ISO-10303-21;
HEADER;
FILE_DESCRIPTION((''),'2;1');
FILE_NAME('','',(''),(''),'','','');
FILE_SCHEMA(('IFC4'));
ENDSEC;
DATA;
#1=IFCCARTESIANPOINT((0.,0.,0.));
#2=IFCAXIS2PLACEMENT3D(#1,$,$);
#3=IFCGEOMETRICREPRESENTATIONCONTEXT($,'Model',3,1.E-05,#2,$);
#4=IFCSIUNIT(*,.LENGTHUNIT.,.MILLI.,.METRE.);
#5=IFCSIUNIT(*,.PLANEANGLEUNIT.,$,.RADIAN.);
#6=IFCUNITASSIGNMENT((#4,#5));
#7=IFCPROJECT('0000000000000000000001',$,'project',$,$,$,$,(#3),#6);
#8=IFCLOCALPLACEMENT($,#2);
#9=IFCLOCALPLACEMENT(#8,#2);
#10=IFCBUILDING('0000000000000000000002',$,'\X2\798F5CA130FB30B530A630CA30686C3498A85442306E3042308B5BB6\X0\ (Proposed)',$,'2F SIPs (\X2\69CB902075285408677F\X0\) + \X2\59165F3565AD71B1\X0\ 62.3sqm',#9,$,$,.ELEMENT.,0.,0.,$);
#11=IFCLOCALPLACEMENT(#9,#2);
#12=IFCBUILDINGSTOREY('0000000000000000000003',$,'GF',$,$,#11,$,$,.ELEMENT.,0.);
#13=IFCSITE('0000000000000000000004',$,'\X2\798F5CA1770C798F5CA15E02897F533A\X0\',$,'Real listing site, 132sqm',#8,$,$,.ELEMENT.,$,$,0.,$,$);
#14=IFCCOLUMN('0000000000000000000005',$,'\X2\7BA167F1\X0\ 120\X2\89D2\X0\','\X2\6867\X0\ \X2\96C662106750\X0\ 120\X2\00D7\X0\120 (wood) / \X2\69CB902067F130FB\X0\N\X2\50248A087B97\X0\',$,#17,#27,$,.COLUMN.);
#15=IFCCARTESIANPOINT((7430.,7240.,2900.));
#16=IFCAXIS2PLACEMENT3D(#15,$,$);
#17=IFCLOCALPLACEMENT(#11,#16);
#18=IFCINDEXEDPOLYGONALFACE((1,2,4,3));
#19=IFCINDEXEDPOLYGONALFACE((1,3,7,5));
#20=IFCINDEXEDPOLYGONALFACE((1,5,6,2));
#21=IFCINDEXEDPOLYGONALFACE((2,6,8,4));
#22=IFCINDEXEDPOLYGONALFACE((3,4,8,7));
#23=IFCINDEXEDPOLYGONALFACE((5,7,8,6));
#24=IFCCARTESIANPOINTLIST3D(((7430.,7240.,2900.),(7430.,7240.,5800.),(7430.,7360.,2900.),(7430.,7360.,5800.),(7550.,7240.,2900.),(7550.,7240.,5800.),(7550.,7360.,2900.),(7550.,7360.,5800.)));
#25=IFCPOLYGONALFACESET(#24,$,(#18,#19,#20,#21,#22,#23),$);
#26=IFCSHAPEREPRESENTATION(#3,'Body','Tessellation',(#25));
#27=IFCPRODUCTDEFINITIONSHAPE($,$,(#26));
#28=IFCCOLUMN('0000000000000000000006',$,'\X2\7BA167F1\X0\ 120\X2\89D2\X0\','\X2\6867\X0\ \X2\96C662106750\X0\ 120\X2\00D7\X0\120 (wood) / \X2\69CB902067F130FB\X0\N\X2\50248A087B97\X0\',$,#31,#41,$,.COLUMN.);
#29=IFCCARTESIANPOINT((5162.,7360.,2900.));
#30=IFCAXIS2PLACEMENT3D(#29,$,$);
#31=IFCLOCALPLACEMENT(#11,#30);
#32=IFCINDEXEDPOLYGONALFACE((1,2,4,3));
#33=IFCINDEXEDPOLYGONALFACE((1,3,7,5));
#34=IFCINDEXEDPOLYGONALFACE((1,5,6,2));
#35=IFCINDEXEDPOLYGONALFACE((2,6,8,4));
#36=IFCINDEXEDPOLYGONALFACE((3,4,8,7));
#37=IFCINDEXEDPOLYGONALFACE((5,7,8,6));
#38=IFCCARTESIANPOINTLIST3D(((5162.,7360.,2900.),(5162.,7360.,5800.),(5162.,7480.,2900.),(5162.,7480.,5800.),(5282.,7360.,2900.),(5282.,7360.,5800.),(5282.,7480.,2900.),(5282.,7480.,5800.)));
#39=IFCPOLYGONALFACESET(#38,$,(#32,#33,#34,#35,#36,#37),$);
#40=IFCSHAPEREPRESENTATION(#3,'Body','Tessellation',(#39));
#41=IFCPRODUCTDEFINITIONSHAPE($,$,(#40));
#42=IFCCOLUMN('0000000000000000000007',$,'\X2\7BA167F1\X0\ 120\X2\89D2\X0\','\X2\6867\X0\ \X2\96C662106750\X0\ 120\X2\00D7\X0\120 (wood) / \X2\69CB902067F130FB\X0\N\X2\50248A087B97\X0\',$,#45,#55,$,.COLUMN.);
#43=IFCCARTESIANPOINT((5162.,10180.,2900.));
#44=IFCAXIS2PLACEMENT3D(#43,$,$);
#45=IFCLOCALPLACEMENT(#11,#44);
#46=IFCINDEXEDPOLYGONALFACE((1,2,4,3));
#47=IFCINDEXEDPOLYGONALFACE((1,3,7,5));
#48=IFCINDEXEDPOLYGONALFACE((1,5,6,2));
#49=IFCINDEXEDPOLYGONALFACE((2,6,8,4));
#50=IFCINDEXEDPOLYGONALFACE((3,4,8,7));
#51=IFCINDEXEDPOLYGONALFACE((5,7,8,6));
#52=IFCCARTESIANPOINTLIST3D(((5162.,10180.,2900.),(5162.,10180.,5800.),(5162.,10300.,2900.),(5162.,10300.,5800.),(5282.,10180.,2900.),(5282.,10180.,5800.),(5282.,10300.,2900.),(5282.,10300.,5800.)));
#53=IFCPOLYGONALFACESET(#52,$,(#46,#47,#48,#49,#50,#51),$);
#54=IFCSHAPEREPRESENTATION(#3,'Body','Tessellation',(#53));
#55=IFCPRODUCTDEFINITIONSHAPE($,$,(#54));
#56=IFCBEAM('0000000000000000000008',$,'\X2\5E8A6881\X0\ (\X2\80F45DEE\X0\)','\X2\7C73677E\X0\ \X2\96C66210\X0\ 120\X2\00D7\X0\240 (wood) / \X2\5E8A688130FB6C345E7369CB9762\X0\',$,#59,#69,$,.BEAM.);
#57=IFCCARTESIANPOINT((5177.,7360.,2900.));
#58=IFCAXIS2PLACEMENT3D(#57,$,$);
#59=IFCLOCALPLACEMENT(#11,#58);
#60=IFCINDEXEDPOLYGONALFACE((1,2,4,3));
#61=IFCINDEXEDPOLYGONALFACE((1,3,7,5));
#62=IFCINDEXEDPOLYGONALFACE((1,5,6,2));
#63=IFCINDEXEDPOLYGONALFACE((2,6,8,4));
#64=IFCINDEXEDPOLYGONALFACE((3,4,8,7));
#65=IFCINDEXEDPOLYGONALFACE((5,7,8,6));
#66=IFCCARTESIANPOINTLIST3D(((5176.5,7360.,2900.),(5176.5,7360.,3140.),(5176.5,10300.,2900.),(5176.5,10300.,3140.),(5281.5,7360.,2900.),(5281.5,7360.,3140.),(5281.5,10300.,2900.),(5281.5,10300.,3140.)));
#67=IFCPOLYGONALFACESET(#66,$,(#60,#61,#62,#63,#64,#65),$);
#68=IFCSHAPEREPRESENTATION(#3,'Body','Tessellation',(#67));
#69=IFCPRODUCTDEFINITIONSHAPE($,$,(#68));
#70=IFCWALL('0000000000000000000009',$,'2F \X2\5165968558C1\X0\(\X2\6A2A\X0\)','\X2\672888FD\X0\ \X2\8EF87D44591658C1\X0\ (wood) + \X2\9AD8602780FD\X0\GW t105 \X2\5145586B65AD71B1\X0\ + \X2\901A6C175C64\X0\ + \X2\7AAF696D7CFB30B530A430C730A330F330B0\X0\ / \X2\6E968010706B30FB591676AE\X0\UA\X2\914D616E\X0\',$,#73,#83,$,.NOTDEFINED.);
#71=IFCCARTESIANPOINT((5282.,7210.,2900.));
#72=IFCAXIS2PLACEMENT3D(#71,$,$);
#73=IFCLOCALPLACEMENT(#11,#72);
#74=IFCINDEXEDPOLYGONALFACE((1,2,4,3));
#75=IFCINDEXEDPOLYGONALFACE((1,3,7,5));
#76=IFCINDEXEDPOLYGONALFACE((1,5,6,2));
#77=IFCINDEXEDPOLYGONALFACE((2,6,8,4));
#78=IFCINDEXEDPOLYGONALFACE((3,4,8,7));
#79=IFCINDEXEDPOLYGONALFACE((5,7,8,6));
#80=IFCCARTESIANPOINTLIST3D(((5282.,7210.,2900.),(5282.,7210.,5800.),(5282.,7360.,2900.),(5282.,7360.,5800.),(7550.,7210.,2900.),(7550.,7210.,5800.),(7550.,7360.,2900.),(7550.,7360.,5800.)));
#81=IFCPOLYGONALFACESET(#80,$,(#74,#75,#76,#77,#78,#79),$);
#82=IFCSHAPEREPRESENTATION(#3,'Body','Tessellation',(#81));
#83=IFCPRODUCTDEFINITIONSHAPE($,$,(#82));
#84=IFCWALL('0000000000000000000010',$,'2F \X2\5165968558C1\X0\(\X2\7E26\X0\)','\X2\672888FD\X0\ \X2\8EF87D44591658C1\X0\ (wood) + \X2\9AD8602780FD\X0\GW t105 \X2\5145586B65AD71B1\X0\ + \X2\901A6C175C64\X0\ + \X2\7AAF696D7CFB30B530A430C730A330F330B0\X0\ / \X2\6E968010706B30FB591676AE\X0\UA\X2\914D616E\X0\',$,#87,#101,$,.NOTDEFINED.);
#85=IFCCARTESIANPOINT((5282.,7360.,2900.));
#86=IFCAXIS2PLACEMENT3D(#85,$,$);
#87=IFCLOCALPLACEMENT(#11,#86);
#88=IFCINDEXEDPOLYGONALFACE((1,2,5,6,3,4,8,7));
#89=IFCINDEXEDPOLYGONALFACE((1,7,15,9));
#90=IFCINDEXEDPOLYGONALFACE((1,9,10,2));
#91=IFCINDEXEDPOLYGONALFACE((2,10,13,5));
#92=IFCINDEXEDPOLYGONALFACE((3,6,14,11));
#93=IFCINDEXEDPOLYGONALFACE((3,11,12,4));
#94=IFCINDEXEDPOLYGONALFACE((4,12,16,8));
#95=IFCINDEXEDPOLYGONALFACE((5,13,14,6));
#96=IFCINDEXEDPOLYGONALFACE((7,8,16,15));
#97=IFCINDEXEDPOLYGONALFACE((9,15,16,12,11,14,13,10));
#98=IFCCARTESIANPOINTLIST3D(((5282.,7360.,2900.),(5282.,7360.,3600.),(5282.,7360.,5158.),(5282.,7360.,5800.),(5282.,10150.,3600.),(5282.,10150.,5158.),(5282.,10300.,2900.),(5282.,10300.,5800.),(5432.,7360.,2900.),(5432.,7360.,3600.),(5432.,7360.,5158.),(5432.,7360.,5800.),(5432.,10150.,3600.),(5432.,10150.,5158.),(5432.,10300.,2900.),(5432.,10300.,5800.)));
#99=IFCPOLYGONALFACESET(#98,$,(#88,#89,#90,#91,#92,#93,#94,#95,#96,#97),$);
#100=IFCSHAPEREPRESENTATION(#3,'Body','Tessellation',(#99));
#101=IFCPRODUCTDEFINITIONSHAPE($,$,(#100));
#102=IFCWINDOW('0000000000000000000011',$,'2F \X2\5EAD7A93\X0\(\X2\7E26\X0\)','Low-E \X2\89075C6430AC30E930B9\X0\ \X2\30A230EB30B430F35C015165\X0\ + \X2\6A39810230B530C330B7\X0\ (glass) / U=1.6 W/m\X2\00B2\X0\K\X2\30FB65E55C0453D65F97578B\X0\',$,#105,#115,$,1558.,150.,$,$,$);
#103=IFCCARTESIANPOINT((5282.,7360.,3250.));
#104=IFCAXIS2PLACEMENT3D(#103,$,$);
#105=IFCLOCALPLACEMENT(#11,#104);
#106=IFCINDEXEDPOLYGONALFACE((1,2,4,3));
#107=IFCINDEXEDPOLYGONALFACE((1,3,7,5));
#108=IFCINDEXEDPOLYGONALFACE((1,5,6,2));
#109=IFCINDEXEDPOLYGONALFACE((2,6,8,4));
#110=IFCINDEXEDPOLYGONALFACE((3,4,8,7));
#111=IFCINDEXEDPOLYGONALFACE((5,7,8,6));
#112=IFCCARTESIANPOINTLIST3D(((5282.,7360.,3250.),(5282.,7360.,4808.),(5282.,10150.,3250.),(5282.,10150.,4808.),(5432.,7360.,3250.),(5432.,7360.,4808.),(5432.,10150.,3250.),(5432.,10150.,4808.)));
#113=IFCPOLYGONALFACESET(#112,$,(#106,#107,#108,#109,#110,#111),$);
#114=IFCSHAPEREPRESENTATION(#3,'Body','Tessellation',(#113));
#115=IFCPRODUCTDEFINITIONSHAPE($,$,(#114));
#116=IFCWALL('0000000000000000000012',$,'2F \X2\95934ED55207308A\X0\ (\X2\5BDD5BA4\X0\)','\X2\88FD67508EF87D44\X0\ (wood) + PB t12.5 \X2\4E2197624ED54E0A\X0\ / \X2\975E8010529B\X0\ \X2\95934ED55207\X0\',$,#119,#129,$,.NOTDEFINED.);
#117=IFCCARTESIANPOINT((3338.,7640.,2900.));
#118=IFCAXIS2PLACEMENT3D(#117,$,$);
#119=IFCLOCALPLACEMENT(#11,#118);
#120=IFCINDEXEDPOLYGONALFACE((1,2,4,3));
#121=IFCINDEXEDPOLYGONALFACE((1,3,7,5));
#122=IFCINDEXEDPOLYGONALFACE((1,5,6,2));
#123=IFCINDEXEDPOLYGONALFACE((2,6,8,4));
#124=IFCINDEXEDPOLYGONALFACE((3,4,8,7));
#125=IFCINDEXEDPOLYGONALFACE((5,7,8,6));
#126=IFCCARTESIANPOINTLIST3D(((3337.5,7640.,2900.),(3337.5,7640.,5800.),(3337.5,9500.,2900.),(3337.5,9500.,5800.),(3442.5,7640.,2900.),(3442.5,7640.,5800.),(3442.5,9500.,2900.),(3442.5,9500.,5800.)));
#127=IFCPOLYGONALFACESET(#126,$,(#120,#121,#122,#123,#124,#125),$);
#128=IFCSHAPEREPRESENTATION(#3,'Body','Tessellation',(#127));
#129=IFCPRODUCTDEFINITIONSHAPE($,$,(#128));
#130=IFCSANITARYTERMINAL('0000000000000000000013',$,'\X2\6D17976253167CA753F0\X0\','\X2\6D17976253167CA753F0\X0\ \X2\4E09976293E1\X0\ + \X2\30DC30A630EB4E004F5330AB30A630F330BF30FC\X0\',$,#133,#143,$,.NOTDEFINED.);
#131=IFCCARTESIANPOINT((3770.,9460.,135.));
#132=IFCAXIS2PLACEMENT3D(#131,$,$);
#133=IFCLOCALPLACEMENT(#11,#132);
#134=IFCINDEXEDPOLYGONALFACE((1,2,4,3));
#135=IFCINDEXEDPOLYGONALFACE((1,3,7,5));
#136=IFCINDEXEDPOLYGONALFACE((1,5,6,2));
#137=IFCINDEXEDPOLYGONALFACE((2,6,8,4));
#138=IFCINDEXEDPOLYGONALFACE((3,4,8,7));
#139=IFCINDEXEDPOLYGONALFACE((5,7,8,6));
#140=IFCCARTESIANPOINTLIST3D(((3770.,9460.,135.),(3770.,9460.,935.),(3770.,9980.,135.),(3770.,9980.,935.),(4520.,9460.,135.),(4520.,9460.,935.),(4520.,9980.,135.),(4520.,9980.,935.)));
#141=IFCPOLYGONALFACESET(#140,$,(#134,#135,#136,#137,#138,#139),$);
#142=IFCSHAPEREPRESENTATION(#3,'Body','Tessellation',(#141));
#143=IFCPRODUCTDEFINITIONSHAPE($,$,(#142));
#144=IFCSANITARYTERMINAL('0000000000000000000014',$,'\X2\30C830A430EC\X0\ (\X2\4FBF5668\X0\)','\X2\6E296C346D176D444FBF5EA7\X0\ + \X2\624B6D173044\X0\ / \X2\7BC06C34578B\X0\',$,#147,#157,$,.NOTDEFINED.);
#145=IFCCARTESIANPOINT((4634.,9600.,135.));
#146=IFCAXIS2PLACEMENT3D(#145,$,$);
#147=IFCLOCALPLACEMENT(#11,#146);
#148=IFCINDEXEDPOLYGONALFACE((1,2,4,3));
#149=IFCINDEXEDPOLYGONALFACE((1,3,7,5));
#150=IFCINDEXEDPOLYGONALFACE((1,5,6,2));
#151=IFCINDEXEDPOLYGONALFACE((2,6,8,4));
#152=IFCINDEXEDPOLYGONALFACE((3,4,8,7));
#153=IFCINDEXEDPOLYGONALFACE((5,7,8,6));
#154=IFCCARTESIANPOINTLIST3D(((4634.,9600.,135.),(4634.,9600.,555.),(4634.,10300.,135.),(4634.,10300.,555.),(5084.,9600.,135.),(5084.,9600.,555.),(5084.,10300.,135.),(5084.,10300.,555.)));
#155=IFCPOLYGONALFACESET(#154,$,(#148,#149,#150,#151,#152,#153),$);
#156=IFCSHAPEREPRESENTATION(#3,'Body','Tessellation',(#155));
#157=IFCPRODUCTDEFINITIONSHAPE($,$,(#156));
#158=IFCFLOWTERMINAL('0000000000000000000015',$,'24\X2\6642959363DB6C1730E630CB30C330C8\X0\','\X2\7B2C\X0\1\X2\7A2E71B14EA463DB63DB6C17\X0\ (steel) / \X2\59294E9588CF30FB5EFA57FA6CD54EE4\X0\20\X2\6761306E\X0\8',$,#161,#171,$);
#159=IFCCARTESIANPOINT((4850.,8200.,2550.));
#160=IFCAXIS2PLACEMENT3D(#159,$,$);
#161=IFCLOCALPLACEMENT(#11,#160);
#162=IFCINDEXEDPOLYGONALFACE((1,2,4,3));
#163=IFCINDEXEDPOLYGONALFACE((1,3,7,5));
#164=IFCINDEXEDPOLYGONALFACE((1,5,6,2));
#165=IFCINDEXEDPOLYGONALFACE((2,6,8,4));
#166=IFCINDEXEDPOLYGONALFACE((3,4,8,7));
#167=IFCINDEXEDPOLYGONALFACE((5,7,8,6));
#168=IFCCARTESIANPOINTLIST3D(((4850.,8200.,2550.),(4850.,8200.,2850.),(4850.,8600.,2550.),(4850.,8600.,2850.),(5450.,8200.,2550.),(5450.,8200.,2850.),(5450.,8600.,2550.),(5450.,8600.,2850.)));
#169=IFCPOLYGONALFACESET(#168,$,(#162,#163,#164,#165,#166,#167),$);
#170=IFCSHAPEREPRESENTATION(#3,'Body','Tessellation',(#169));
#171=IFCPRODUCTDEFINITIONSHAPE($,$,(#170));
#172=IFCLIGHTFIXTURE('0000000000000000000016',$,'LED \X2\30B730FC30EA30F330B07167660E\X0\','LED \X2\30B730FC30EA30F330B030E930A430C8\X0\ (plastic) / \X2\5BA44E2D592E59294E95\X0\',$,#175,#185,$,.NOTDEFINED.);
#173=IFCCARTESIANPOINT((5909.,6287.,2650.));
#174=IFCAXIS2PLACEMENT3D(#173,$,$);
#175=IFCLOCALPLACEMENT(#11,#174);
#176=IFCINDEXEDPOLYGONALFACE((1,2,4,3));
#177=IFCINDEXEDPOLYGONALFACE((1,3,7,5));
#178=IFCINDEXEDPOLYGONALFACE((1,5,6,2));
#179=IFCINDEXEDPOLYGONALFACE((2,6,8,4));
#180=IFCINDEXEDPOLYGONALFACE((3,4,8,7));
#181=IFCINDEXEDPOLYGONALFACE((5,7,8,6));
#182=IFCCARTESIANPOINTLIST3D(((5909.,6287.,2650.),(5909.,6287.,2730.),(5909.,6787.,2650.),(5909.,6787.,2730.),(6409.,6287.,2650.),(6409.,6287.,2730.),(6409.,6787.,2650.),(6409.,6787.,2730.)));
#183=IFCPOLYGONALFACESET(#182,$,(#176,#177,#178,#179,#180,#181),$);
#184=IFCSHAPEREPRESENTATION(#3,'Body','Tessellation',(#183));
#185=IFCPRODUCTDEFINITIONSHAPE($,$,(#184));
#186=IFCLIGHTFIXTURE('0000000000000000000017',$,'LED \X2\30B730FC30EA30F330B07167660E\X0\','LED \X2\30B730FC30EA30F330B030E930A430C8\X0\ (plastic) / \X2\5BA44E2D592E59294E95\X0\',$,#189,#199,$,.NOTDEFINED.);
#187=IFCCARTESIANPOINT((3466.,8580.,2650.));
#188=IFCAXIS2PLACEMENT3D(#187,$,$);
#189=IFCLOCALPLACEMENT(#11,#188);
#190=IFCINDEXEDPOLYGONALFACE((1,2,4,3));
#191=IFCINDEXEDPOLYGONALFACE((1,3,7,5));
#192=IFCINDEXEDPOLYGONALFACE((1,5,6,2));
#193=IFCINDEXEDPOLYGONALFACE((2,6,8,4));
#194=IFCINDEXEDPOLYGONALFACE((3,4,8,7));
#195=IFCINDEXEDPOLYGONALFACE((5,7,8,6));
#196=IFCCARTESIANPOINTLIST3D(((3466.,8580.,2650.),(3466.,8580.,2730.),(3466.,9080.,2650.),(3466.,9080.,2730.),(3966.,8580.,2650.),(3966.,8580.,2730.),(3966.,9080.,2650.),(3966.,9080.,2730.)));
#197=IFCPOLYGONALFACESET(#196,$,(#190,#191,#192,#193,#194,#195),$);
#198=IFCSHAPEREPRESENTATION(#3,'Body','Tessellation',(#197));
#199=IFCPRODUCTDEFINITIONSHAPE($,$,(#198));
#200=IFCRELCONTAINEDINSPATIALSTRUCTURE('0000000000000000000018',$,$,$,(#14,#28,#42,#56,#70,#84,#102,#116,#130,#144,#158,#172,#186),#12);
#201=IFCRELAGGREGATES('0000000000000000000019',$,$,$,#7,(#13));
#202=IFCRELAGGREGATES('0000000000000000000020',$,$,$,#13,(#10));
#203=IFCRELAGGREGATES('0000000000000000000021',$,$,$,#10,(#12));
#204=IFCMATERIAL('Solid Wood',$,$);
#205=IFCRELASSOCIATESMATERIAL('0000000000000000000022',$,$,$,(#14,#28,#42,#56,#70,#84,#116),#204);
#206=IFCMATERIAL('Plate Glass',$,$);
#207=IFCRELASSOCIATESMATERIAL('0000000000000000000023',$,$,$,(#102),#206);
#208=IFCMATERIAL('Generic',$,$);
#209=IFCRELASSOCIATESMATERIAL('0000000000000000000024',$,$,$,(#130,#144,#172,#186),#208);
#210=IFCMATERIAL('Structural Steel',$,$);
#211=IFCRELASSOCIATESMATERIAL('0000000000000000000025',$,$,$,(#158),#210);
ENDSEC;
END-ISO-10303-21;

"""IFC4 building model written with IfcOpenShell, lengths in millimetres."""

from ifc_helpers import new_model, si_unit, frame, frame_2d, origin, place, context, project, spatial, rectangle, extrude, material, element, fill, save


model = new_model("IFC4")

# Units and contexts
model_context = context("Model", 3, precision=1e-05, world=origin())
ifc_project = project(units=[si_unit("LENGTHUNIT", "METRE", prefix="MILLI"), si_unit("PLANEANGLEUNIT", "RADIAN")], contexts=[model_context])

# Site, building, storey
site_placement = place(None, origin())
site = spatial("IfcSite", under=ifc_project, at=site_placement, Name="福岡県福岡市西区", ObjectType="Real listing site, 132sqm", CompositionType="ELEMENT", RefElevation=0.0)
building_placement = place(site_placement, origin())
building = spatial("IfcBuilding", under=site, at=building_placement, Name="福岡・サウナと水風呂のある家 (Proposed)", ObjectType="2F SIPs (構造用合板) + 外張断熱 62.3sqm", CompositionType="ELEMENT", ElevationOfRefHeight=0.0, ElevationOfTerrain=0.0)
storey_placement = place(building_placement, origin())
storey = spatial("IfcBuildingStorey", under=building, at=storey_placement, Name="GF", CompositionType="ELEMENT", Elevation=0.0)

# Columns
ifc_material_1 = material(Name="Solid Wood")
column_1_placement = place(storey_placement, frame((7430.0, 7240.0, 2900.0)))
element("IfcColumn", 1, at=column_1_placement, inside=storey, material=ifc_material_1, Name="管柱 120角", Description="桧 集成材 120×120 (wood) / 構造柱・N値計算", PredefinedType="COLUMN", context=model_context, shape_type="SweptSolid", body=[
    extrude(rectangle(XDim=120.0, YDim=120.0, at=frame_2d((60.0, 60.0))), frame((7430.0, 7240.0, 2900.0)), (0.0, 0.0, 1.0), 2900.0),
])
column_2_placement = place(storey_placement, frame((5162.0, 7360.0, 2900.0)))
element("IfcColumn", 2, at=column_2_placement, inside=storey, material=ifc_material_1, Name="管柱 120角", Description="桧 集成材 120×120 (wood) / 構造柱・N値計算", PredefinedType="COLUMN", context=model_context, shape_type="SweptSolid", body=[
    extrude(rectangle(XDim=120.0, YDim=120.0, at=frame_2d((60.0, 60.0))), frame((5162.0, 7360.0, 2900.0)), (0.0, 0.0, 1.0), 2900.0),
])
column_3_placement = place(storey_placement, frame((5162.0, 10180.0, 2900.0)))
element("IfcColumn", 3, at=column_3_placement, inside=storey, material=ifc_material_1, Name="管柱 120角", Description="桧 集成材 120×120 (wood) / 構造柱・N値計算", PredefinedType="COLUMN", context=model_context, shape_type="SweptSolid", body=[
    extrude(rectangle(XDim=120.0, YDim=120.0, at=frame_2d((60.0, 60.0))), frame((5162.0, 10180.0, 2900.0)), (0.0, 0.0, 1.0), 2900.0),
])

# Beam
beam_placement = place(storey_placement, frame((5177.0, 7360.0, 2900.0)))
element("IfcBeam", 4, at=beam_placement, inside=storey, material=ifc_material_1, Name="床梁 (胴差)", Description="米松 集成 120×240 (wood) / 床梁・水平構面", PredefinedType="BEAM", context=model_context, shape_type="SweptSolid", body=[
    extrude(rectangle(XDim=105.0, YDim=2940.0, at=frame_2d((52.0, 1470.0))), frame((5177.0, 7360.0, 2900.0)), (0.0, 0.0, 1.0), 240.0),
])

# Wall
wall_1_placement = place(storey_placement, frame((5282.0, 7210.0, 2900.0)))
element("IfcWall", 5, at=wall_1_placement, inside=storey, material=ifc_material_1, Name="2F 入隅壁(横)", Description="木製 軸組外壁 (wood) + 高性能GW t105 充填断熱 + 通気層 + 窯業系サイディング / 準耐火・外皮UA配慮", PredefinedType="NOTDEFINED", context=model_context, shape_type="SweptSolid", body=[
    extrude(rectangle(XDim=2268.0, YDim=150.0, at=frame_2d((1134.0, 75.0))), frame((5282.0, 7210.0, 2900.0)), (0.0, 0.0, 1.0), 2900.0),
])

# Wall, opening, window
wall_2_placement = place(storey_placement, frame((5282.0, 7360.0, 2900.0)))
wall_2 = element("IfcWall", 6, at=wall_2_placement, inside=storey, material=ifc_material_1, Name="2F 入隅壁(縦)", Description="木製 軸組外壁 (wood) + 高性能GW t105 充填断熱 + 通気層 + 窯業系サイディング / 準耐火・外皮UA配慮", PredefinedType="NOTDEFINED", context=model_context, shape_type="SweptSolid", body=[
    extrude(rectangle(XDim=150.0, YDim=2940.0, at=frame_2d((75.0, 1470.0))), frame((5282.0, 7360.0, 2900.0)), (0.0, 0.0, 1.0), 2900.0),
])
opening_placement = place(storey_placement, frame((5282.0, 7360.0, 3250.0)))
opening = element("IfcOpeningElement", 7, at=opening_placement, cuts=wall_2, PredefinedType="NOTDEFINED", context=model_context, shape_type="SweptSolid", body=[
    extrude(rectangle(XDim=150.0, YDim=2790.0, at=frame_2d((75.0, 1395.0))), frame((5282.0, 7360.0, 3250.0)), (0.0, 0.0, 1.0), 1558.0),
])
ifc_material_2 = material(Name="Plate Glass")
window_placement = place(storey_placement, frame((5282.0, 7360.0, 3250.0)))
window = element("IfcWindow", 8, at=window_placement, inside=storey, material=ifc_material_2, Name="2F 庭窓(縦)", Description="Low-E 複層ガラス アルゴン封入 + 樹脂サッシ (glass) / U=1.6 W/m²K・日射取得型", OverallHeight=1558.0, OverallWidth=150.0, context=model_context, shape_type="SweptSolid", body=[
    extrude(rectangle(XDim=150.0, YDim=2790.0, at=frame_2d((75.0, 1395.0))), frame((5282.0, 7360.0, 3250.0)), (0.0, 0.0, 1.0), 1558.0),
])
fill(opening, window)

# Wall
wall_3_placement = place(storey_placement, frame((3338.0, 7640.0, 2900.0)))
element("IfcWall", 9, at=wall_3_placement, inside=storey, material=ifc_material_1, Name="2F 間仕切り (寝室)", Description="製材軸組 (wood) + PB t12.5 両面仕上 / 非耐力 間仕切", PredefinedType="NOTDEFINED", context=model_context, shape_type="SweptSolid", body=[
    extrude(rectangle(XDim=105.0, YDim=1860.0, at=frame_2d((52.0, 930.0))), frame((3338.0, 7640.0, 2900.0)), (0.0, 0.0, 1.0), 2900.0),
])

# Sanitary terminals
ifc_material_3 = material(Name="Generic")
sanitary_terminal_1_placement = place(storey_placement, frame((3770.0, 9460.0, 135.0)))
element("IfcSanitaryTerminal", 10, at=sanitary_terminal_1_placement, inside=storey, material=ifc_material_3, Name="洗面化粧台", Description="洗面化粧台 三面鏡 + ボウル一体カウンター", PredefinedType="NOTDEFINED", context=model_context, shape_type="SweptSolid", body=[
    extrude(rectangle(XDim=750.0, YDim=520.0, at=frame_2d((375.0, 260.0))), frame((3770.0, 9460.0, 135.0)), (0.0, 0.0, 1.0), 800.0),
])
sanitary_terminal_2_placement = place(storey_placement, frame((4634.0, 9600.0, 135.0)))
element("IfcSanitaryTerminal", 11, at=sanitary_terminal_2_placement, inside=storey, material=ifc_material_3, Name="トイレ (便器)", Description="温水洗浄便座 + 手洗い / 節水型", PredefinedType="NOTDEFINED", context=model_context, shape_type="SweptSolid", body=[
    extrude(rectangle(XDim=450.0, YDim=700.0, at=frame_2d((225.0, 350.0))), frame((4634.0, 9600.0, 135.0)), (0.0, 0.0, 1.0), 420.0),
])

# Flow terminal
ifc_material_4 = material(Name="Structural Steel")
flow_terminal_placement = place(storey_placement, frame((4850.0, 8200.0, 2550.0)))
element("IfcFlowTerminal", 12, at=flow_terminal_placement, inside=storey, material=ifc_material_4, Name="24時間換気ユニット", Description="第1種熱交換換気 (steel) / 天井裏・建基法令20条の8", context=model_context, shape_type="SweptSolid", body=[
    extrude(rectangle(XDim=600.0, YDim=400.0, at=frame_2d((300.0, 200.0))), frame((4850.0, 8200.0, 2550.0)), (0.0, 0.0, 1.0), 300.0),
])

# Light fixtures
light_fixture_1_placement = place(storey_placement, frame((5909.0, 6287.0, 2650.0)))
element("IfcLightFixture", 13, at=light_fixture_1_placement, inside=storey, material=ifc_material_3, Name="LED シーリング照明", Description="LED シーリングライト (plastic) / 室中央天井", PredefinedType="NOTDEFINED", context=model_context, shape_type="SweptSolid", body=[
    extrude(rectangle(XDim=500.0, YDim=500.0, at=frame_2d((250.0, 250.0))), frame((5909.0, 6287.0, 2650.0)), (0.0, 0.0, 1.0), 80.0),
])
light_fixture_2_placement = place(storey_placement, frame((3466.0, 8580.0, 2650.0)))
element("IfcLightFixture", 14, at=light_fixture_2_placement, inside=storey, material=ifc_material_3, Name="LED シーリング照明", Description="LED シーリングライト (plastic) / 室中央天井", PredefinedType="NOTDEFINED", context=model_context, shape_type="SweptSolid", body=[
    extrude(rectangle(XDim=500.0, YDim=500.0, at=frame_2d((250.0, 250.0))), frame((3466.0, 8580.0, 2650.0)), (0.0, 0.0, 1.0), 80.0),
])

save(model, "model.ifc")
